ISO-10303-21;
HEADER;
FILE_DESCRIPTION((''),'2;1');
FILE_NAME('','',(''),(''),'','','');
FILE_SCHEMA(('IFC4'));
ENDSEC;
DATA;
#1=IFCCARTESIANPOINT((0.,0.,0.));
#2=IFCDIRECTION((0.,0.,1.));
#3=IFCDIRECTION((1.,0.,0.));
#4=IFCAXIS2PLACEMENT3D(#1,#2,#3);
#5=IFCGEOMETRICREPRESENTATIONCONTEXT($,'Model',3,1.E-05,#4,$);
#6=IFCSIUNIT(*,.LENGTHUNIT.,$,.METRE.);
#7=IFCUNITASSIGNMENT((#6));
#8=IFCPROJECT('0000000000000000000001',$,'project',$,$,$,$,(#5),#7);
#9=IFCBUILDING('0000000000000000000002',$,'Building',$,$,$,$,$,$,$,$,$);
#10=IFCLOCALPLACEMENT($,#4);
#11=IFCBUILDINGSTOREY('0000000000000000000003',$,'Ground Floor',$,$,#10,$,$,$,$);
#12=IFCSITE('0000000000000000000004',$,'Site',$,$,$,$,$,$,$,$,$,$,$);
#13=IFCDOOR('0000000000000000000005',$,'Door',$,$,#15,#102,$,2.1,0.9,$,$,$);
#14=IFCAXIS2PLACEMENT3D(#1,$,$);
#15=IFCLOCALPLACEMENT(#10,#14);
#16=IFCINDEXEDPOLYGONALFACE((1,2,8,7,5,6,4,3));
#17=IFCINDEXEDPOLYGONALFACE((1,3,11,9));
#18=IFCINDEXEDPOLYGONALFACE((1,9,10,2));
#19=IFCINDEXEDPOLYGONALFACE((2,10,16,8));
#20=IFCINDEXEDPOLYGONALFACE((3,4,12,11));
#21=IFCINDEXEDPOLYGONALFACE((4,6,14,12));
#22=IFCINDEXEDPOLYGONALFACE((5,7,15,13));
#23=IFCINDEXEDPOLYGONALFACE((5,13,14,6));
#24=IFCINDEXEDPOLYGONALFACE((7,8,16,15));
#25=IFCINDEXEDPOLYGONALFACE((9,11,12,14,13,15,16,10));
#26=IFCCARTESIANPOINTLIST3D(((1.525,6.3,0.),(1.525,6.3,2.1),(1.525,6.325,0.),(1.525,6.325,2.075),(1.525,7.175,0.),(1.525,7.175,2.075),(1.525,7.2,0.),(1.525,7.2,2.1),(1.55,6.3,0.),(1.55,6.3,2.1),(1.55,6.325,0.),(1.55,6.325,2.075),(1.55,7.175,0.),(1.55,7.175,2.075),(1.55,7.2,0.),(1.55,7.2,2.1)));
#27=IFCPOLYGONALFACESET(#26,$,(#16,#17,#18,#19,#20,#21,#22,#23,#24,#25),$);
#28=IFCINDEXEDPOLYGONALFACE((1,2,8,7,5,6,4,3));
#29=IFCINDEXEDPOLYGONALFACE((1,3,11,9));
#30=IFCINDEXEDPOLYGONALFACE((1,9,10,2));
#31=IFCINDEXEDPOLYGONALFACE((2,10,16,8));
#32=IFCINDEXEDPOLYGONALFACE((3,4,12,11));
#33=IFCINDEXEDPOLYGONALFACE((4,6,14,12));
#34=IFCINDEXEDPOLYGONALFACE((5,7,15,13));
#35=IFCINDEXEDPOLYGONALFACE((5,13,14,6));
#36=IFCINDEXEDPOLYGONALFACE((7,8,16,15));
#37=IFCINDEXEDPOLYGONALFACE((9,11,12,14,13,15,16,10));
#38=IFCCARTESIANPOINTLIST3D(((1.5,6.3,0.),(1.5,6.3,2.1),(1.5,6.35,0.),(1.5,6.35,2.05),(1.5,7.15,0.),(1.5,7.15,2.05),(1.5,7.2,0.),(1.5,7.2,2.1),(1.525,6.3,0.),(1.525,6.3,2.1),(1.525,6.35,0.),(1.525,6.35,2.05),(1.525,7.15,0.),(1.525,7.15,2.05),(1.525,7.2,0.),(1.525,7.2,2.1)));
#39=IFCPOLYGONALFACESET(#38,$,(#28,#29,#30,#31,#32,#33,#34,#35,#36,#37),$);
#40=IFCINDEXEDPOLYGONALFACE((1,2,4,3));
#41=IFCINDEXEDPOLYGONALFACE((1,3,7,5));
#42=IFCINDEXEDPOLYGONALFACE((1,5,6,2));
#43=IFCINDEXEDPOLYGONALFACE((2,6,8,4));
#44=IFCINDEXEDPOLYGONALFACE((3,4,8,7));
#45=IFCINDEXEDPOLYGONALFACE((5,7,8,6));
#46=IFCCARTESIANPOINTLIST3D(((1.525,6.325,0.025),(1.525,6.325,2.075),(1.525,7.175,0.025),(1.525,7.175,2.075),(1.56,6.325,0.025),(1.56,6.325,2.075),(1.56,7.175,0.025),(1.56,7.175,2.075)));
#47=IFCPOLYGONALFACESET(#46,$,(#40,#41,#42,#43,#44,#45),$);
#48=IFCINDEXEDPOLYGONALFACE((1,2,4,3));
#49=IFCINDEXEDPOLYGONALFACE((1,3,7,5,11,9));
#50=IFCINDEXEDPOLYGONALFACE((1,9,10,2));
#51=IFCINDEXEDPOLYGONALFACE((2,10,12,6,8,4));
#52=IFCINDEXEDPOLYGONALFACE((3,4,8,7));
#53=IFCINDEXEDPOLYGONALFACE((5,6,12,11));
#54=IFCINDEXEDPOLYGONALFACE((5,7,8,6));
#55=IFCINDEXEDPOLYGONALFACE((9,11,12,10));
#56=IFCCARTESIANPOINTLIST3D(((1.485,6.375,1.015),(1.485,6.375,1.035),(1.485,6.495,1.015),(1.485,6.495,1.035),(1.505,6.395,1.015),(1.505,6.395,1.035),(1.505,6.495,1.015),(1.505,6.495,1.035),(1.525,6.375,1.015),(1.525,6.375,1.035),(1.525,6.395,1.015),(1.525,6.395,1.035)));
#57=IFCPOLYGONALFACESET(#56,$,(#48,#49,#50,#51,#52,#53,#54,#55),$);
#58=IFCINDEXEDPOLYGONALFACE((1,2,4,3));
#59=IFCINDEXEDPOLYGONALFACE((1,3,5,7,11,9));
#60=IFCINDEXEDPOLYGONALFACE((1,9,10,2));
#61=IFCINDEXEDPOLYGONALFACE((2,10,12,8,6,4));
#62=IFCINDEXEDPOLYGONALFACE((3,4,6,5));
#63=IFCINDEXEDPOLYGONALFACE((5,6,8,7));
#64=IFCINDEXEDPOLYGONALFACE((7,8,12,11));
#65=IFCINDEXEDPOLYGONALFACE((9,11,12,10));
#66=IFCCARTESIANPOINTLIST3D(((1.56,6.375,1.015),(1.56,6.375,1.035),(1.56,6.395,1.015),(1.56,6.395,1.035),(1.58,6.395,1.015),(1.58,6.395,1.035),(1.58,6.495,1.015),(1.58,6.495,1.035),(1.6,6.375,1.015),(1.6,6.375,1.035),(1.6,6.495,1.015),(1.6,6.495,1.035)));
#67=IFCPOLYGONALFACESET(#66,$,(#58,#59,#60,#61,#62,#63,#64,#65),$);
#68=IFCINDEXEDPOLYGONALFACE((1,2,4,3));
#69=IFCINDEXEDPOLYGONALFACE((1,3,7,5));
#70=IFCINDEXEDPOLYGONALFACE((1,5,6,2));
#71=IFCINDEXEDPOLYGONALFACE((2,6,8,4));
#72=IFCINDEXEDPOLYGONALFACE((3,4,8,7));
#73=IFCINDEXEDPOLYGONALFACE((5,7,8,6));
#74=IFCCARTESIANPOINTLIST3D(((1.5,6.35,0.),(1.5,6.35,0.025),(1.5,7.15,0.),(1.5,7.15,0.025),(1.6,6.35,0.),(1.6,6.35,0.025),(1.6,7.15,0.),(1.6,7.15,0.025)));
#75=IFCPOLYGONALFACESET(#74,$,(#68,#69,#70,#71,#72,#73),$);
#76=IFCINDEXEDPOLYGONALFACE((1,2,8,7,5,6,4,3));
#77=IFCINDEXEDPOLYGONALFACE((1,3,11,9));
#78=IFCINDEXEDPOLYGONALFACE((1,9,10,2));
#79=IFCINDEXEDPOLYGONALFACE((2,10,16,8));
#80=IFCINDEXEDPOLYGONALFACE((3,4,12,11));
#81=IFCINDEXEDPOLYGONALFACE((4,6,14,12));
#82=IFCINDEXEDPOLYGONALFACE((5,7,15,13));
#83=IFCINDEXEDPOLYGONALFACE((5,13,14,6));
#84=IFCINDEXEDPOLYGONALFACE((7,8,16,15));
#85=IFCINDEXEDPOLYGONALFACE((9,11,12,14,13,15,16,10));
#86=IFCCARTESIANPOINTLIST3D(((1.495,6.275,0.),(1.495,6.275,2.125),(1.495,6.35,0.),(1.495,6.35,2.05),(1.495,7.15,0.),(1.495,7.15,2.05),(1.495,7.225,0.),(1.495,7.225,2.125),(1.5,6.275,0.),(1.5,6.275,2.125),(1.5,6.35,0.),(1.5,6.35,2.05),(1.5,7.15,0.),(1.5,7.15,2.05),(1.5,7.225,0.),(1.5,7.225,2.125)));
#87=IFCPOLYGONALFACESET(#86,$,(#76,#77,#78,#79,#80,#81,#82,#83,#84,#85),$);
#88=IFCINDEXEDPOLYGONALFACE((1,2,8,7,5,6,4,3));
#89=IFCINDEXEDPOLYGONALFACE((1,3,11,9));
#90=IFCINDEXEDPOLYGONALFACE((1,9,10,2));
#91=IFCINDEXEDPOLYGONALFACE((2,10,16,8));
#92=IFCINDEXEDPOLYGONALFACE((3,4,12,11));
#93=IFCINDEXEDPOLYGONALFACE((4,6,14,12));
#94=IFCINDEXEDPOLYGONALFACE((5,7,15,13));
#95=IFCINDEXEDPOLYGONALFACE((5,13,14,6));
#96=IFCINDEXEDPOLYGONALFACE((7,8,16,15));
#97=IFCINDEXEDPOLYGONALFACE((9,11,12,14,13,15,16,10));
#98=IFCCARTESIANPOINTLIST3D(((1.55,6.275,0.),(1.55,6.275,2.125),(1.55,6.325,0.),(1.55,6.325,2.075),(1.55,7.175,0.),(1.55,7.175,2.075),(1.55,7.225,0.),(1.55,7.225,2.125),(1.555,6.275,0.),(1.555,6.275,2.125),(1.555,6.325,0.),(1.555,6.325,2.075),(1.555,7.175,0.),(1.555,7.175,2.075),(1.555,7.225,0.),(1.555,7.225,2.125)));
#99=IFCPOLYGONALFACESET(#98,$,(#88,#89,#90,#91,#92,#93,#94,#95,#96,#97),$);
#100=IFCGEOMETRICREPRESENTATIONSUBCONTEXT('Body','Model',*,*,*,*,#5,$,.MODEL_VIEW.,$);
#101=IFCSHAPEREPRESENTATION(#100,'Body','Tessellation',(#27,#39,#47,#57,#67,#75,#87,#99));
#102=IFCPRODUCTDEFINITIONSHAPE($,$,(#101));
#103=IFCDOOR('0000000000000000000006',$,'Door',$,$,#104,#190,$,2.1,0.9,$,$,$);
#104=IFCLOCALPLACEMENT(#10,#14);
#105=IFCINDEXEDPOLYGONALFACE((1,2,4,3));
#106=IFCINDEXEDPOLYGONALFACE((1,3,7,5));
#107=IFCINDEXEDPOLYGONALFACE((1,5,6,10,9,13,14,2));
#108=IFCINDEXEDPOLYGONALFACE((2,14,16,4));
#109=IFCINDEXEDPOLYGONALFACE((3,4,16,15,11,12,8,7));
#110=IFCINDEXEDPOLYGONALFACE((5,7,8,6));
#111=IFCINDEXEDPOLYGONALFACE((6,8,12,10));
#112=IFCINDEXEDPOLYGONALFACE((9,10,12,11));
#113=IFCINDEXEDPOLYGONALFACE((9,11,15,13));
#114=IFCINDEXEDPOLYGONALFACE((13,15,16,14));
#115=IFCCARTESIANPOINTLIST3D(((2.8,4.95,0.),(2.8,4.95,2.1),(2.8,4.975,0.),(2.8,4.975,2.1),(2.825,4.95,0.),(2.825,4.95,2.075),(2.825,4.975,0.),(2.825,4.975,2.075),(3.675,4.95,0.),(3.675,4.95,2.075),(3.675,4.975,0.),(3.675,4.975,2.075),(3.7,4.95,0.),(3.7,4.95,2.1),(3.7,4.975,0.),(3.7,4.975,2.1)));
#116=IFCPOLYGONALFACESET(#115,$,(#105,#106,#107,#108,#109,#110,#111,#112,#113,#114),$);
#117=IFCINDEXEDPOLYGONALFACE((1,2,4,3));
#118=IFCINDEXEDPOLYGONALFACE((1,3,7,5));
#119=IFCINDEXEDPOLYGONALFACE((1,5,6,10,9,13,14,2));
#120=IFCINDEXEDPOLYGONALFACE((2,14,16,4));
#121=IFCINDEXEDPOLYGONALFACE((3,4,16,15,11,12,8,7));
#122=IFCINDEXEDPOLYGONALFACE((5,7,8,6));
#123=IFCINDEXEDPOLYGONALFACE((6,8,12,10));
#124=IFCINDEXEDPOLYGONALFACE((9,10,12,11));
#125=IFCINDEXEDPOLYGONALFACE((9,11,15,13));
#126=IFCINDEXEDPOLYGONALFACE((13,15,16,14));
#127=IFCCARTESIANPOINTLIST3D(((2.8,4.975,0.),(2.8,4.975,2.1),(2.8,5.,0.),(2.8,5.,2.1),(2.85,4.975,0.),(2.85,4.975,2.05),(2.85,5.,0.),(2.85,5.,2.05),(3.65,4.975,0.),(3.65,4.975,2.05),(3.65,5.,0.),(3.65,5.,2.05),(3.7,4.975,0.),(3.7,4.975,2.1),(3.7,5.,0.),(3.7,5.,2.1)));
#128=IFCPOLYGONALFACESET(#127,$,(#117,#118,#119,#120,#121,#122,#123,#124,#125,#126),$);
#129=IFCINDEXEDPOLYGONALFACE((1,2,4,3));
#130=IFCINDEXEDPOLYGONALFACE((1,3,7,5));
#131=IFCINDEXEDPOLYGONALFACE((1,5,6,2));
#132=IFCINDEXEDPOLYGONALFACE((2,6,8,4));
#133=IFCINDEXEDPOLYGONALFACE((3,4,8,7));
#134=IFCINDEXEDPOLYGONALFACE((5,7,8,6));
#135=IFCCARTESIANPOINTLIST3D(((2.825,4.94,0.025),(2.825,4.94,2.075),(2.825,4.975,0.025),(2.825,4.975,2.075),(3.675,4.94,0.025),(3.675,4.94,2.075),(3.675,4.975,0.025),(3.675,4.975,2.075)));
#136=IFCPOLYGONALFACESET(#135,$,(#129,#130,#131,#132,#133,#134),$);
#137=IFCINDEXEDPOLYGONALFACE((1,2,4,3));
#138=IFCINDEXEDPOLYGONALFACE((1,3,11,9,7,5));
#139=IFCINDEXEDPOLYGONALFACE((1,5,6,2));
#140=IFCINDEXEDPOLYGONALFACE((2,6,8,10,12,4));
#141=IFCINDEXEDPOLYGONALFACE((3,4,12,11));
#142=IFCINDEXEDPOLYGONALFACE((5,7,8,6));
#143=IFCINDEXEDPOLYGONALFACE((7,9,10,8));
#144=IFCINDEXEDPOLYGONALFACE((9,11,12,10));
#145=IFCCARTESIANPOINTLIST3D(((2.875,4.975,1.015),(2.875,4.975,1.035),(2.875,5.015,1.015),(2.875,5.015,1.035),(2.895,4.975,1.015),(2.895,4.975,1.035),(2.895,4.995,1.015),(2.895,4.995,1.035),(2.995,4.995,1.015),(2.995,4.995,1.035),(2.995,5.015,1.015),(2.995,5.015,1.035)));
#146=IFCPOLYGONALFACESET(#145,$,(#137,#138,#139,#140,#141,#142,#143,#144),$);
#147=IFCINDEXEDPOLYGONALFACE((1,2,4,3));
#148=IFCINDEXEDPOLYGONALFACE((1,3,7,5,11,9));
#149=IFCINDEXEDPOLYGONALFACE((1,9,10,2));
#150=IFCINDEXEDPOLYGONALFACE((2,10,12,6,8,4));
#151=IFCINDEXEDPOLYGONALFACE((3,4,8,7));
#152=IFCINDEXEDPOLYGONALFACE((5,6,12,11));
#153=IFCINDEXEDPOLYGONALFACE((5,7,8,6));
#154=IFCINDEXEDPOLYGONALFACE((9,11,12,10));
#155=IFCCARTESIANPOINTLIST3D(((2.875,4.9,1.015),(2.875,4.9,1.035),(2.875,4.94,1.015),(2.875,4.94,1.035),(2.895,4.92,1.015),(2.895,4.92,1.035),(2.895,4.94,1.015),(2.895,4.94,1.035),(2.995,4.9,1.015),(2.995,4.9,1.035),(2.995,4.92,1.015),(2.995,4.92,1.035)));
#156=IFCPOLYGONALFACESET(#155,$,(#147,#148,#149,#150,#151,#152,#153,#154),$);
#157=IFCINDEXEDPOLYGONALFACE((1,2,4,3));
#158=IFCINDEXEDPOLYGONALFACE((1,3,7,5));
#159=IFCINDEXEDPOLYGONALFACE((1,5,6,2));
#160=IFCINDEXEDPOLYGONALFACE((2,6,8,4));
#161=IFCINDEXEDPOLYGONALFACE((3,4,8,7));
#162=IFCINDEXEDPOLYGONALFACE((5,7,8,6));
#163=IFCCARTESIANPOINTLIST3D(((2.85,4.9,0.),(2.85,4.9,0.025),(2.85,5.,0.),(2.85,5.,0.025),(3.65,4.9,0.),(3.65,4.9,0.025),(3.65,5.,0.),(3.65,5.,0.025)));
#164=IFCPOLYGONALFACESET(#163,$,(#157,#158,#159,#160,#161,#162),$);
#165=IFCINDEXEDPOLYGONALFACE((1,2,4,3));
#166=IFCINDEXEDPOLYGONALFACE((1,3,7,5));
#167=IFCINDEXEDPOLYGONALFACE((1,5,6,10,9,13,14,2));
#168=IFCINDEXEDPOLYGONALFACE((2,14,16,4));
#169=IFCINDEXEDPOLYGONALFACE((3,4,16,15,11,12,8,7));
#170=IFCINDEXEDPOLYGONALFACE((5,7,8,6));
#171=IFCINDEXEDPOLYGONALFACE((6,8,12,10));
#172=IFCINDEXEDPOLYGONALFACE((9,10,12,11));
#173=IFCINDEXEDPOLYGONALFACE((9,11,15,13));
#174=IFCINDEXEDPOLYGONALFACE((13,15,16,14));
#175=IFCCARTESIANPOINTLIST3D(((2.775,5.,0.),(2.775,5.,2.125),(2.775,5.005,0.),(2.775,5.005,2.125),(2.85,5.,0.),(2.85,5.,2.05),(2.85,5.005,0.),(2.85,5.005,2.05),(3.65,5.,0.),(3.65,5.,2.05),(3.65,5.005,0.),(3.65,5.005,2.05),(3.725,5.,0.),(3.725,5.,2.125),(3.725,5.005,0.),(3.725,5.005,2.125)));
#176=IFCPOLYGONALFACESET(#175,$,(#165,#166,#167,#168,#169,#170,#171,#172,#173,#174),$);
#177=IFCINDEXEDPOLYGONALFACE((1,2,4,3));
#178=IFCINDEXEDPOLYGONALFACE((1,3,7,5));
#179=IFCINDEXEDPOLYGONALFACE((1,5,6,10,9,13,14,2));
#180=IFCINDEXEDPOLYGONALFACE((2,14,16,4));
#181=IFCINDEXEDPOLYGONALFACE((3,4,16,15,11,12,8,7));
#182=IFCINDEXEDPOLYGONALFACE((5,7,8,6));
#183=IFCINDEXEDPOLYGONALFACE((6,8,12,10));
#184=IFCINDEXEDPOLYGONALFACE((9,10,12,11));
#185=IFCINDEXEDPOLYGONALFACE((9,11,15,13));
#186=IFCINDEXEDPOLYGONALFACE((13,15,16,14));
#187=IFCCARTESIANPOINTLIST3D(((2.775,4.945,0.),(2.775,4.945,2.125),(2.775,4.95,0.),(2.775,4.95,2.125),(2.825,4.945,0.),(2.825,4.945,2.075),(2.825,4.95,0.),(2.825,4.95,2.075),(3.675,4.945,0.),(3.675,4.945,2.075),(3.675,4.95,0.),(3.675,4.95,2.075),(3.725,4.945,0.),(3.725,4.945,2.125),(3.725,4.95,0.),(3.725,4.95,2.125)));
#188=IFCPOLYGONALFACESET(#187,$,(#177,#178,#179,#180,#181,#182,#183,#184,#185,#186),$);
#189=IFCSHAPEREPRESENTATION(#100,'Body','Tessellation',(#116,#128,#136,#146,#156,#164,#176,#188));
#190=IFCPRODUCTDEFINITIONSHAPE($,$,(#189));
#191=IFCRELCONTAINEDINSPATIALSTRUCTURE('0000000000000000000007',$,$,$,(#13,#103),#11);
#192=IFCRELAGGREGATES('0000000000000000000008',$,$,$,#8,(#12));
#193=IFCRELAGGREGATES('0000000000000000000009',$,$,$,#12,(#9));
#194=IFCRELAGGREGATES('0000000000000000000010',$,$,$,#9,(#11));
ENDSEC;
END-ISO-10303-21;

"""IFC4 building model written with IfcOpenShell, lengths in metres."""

from ifc_helpers import new_model, si_unit, frame, origin_with_axes, place, context, subcontext, project, spatial, line, indexed_curve, outline, extrude, element, save


model = new_model("IFC4")

# Units and contexts
model_context = context("Model", 3, precision=1e-05, world=origin_with_axes())
body_context = subcontext(model_context, "Body", "Model", "MODEL_VIEW")
ifc_project = project(units=[si_unit("LENGTHUNIT", "METRE")], contexts=[model_context])

# Site, building, storey
site = spatial("IfcSite", under=ifc_project, Name="Site")
building = spatial("IfcBuilding", under=site, Name="Building")
storey_placement = place(None, origin_with_axes())
storey = spatial("IfcBuildingStorey", under=building, at=storey_placement, Name="Ground Floor")

# Doors
door_1_placement = place(storey_placement, frame((1.5, 7.2, 0.0), z_axis=(0.0, 0.0, 1.0), x_axis=(0.0, -1.0, 0.0)))
element("IfcDoor", 1, at=door_1_placement, inside=storey, Name="Door", OverallHeight=2.1, OverallWidth=0.9, context=body_context, shape_type="SweptSolid", body=[
    extrude(outline(indexed_curve([(0.0, 0.0), (0.0, 2.1), (0.9, 2.1), (0.9, 0.0), (0.875, 0.0), (0.875, 2.075), (0.025, 2.075), (0.025, 0.0)], segments=[line(1, 2, 3, 4, 5, 6, 7, 8, 1)])), frame((0.0, 0.025, 0.0), z_axis=(0.0, -1.0, 0.0), x_axis=(1.0, 0.0, 0.0)), (0.0, 0.0, -1.0), 0.025),
    extrude(outline(indexed_curve([(0.0, 0.0), (0.0, 2.1), (0.9, 2.1), (0.9, 0.0), (0.85, 0.0), (0.85, 2.05), (0.05, 2.05), (0.05, 0.0)], segments=[line(1, 2, 3, 4, 5, 6, 7, 8, 1)])), frame((0.0, 0.0, 0.0), z_axis=(0.0, -1.0, 0.0), x_axis=(1.0, 0.0, 0.0)), (0.0, 0.0, -1.0), 0.025),
    extrude(outline(indexed_curve([(0.0, 0.0), (0.85, 0.0), (0.85, 0.035), (0.0, 0.035)], segments=[line(1, 2, 3, 4, 1)])), frame((0.025, 0.025, 0.025), z_axis=(0.0, 0.0, 1.0), x_axis=(1.0, 0.0, 0.0)), (0.0, 0.0, 1.0), 2.05),
    extrude(outline(indexed_curve([(0.0, 0.0), (0.0, -0.04), (-0.12, -0.04), (-0.12, -0.02), (-0.02, -0.02), (-0.02, 0.0)], segments=[line(1, 2, 3, 4, 5, 6, 1)])), frame((0.825, 0.025, 1.015), z_axis=(0.0, 0.0, 1.0), x_axis=(1.0, 0.0, 0.0)), (0.0, 0.0, 1.0), 0.02),
    extrude(outline(indexed_curve([(0.0, 0.0), (0.0, 0.04), (-0.12, 0.04), (-0.12, 0.02), (-0.02, 0.02), (-0.02, 0.0)], segments=[line(1, 2, 3, 4, 5, 6, 1)])), frame((0.825, 0.06, 1.015), z_axis=(0.0, 0.0, 1.0), x_axis=(1.0, 0.0, 0.0)), (0.0, 0.0, 1.0), 0.02),
    extrude(outline(indexed_curve([(0.0, 0.0), (0.8, 0.0), (0.8, 0.1), (0.0, 0.1)], segments=[line(1, 2, 3, 4, 1)])), frame((0.05, 0.0, 0.0), z_axis=(0.0, 0.0, 1.0), x_axis=(1.0, 0.0, 0.0)), (0.0, 0.0, 1.0), 0.025),
    extrude(outline(indexed_curve([(0.0, 0.0), (0.0, 2.125), (0.95, 2.125), (0.95, 0.0), (0.875, 0.0), (0.875, 2.05), (0.075, 2.05), (0.075, 0.0)], segments=[line(1, 2, 3, 4, 5, 6, 7, 8, 1)])), frame((-0.025, -0.005, 0.0), z_axis=(0.0, -1.0, 0.0), x_axis=(1.0, 0.0, 0.0)), (0.0, 0.0, -1.0), 0.005),
    extrude(outline(indexed_curve([(0.0, 0.0), (0.0, 2.125), (0.95, 2.125), (0.95, 0.0), (0.9, 0.0), (0.9, 2.075), (0.05, 2.075), (0.05, 0.0)], segments=[line(1, 2, 3, 4, 5, 6, 7, 8, 1)])), frame((-0.025, 0.05, 0.0), z_axis=(0.0, -1.0, 0.0), x_axis=(1.0, 0.0, 0.0)), (0.0, 0.0, -1.0), 0.005),
])
door_2_placement = place(storey_placement, frame((3.7, 5.0, 0.0), z_axis=(0.0, 0.0, 1.0), x_axis=(-1.0, 0.0, 0.0)))
element("IfcDoor", 2, at=door_2_placement, inside=storey, Name="Door", OverallHeight=2.1, OverallWidth=0.9, context=body_context, shape_type="SweptSolid", body=[
    extrude(outline(indexed_curve([(0.0, 0.0), (0.0, 2.1), (0.9, 2.1), (0.9, 0.0), (0.875, 0.0), (0.875, 2.075), (0.025, 2.075), (0.025, 0.0)], segments=[line(1, 2, 3, 4, 5, 6, 7, 8, 1)])), frame((0.0, 0.025, 0.0), z_axis=(0.0, -1.0, 0.0), x_axis=(1.0, 0.0, 0.0)), (0.0, 0.0, -1.0), 0.025),
    extrude(outline(indexed_curve([(0.0, 0.0), (0.0, 2.1), (0.9, 2.1), (0.9, 0.0), (0.85, 0.0), (0.85, 2.05), (0.05, 2.05), (0.05, 0.0)], segments=[line(1, 2, 3, 4, 5, 6, 7, 8, 1)])), frame((0.0, 0.0, 0.0), z_axis=(0.0, -1.0, 0.0), x_axis=(1.0, 0.0, 0.0)), (0.0, 0.0, -1.0), 0.025),
    extrude(outline(indexed_curve([(0.0, 0.0), (0.85, 0.0), (0.85, 0.035), (0.0, 0.035)], segments=[line(1, 2, 3, 4, 1)])), frame((0.025, 0.025, 0.025), z_axis=(0.0, 0.0, 1.0), x_axis=(1.0, 0.0, 0.0)), (0.0, 0.0, 1.0), 2.05),
    extrude(outline(indexed_curve([(0.0, 0.0), (0.0, -0.04), (-0.12, -0.04), (-0.12, -0.02), (-0.02, -0.02), (-0.02, 0.0)], segments=[line(1, 2, 3, 4, 5, 6, 1)])), frame((0.825, 0.025, 1.015), z_axis=(0.0, 0.0, 1.0), x_axis=(1.0, 0.0, 0.0)), (0.0, 0.0, 1.0), 0.02),
    extrude(outline(indexed_curve([(0.0, 0.0), (0.0, 0.04), (-0.12, 0.04), (-0.12, 0.02), (-0.02, 0.02), (-0.02, 0.0)], segments=[line(1, 2, 3, 4, 5, 6, 1)])), frame((0.825, 0.06, 1.015), z_axis=(0.0, 0.0, 1.0), x_axis=(1.0, 0.0, 0.0)), (0.0, 0.0, 1.0), 0.02),
    extrude(outline(indexed_curve([(0.0, 0.0), (0.8, 0.0), (0.8, 0.1), (0.0, 0.1)], segments=[line(1, 2, 3, 4, 1)])), frame((0.05, 0.0, 0.0), z_axis=(0.0, 0.0, 1.0), x_axis=(1.0, 0.0, 0.0)), (0.0, 0.0, 1.0), 0.025),
    extrude(outline(indexed_curve([(0.0, 0.0), (0.0, 2.125), (0.95, 2.125), (0.95, 0.0), (0.875, 0.0), (0.875, 2.05), (0.075, 2.05), (0.075, 0.0)], segments=[line(1, 2, 3, 4, 5, 6, 7, 8, 1)])), frame((-0.025, -0.005, 0.0), z_axis=(0.0, -1.0, 0.0), x_axis=(1.0, 0.0, 0.0)), (0.0, 0.0, -1.0), 0.005),
    extrude(outline(indexed_curve([(0.0, 0.0), (0.0, 2.125), (0.95, 2.125), (0.95, 0.0), (0.9, 0.0), (0.9, 2.075), (0.05, 2.075), (0.05, 0.0)], segments=[line(1, 2, 3, 4, 5, 6, 7, 8, 1)])), frame((-0.025, 0.05, 0.0), z_axis=(0.0, -1.0, 0.0), x_axis=(1.0, 0.0, 0.0)), (0.0, 0.0, -1.0), 0.005),
])

save(model, "model.ifc")
